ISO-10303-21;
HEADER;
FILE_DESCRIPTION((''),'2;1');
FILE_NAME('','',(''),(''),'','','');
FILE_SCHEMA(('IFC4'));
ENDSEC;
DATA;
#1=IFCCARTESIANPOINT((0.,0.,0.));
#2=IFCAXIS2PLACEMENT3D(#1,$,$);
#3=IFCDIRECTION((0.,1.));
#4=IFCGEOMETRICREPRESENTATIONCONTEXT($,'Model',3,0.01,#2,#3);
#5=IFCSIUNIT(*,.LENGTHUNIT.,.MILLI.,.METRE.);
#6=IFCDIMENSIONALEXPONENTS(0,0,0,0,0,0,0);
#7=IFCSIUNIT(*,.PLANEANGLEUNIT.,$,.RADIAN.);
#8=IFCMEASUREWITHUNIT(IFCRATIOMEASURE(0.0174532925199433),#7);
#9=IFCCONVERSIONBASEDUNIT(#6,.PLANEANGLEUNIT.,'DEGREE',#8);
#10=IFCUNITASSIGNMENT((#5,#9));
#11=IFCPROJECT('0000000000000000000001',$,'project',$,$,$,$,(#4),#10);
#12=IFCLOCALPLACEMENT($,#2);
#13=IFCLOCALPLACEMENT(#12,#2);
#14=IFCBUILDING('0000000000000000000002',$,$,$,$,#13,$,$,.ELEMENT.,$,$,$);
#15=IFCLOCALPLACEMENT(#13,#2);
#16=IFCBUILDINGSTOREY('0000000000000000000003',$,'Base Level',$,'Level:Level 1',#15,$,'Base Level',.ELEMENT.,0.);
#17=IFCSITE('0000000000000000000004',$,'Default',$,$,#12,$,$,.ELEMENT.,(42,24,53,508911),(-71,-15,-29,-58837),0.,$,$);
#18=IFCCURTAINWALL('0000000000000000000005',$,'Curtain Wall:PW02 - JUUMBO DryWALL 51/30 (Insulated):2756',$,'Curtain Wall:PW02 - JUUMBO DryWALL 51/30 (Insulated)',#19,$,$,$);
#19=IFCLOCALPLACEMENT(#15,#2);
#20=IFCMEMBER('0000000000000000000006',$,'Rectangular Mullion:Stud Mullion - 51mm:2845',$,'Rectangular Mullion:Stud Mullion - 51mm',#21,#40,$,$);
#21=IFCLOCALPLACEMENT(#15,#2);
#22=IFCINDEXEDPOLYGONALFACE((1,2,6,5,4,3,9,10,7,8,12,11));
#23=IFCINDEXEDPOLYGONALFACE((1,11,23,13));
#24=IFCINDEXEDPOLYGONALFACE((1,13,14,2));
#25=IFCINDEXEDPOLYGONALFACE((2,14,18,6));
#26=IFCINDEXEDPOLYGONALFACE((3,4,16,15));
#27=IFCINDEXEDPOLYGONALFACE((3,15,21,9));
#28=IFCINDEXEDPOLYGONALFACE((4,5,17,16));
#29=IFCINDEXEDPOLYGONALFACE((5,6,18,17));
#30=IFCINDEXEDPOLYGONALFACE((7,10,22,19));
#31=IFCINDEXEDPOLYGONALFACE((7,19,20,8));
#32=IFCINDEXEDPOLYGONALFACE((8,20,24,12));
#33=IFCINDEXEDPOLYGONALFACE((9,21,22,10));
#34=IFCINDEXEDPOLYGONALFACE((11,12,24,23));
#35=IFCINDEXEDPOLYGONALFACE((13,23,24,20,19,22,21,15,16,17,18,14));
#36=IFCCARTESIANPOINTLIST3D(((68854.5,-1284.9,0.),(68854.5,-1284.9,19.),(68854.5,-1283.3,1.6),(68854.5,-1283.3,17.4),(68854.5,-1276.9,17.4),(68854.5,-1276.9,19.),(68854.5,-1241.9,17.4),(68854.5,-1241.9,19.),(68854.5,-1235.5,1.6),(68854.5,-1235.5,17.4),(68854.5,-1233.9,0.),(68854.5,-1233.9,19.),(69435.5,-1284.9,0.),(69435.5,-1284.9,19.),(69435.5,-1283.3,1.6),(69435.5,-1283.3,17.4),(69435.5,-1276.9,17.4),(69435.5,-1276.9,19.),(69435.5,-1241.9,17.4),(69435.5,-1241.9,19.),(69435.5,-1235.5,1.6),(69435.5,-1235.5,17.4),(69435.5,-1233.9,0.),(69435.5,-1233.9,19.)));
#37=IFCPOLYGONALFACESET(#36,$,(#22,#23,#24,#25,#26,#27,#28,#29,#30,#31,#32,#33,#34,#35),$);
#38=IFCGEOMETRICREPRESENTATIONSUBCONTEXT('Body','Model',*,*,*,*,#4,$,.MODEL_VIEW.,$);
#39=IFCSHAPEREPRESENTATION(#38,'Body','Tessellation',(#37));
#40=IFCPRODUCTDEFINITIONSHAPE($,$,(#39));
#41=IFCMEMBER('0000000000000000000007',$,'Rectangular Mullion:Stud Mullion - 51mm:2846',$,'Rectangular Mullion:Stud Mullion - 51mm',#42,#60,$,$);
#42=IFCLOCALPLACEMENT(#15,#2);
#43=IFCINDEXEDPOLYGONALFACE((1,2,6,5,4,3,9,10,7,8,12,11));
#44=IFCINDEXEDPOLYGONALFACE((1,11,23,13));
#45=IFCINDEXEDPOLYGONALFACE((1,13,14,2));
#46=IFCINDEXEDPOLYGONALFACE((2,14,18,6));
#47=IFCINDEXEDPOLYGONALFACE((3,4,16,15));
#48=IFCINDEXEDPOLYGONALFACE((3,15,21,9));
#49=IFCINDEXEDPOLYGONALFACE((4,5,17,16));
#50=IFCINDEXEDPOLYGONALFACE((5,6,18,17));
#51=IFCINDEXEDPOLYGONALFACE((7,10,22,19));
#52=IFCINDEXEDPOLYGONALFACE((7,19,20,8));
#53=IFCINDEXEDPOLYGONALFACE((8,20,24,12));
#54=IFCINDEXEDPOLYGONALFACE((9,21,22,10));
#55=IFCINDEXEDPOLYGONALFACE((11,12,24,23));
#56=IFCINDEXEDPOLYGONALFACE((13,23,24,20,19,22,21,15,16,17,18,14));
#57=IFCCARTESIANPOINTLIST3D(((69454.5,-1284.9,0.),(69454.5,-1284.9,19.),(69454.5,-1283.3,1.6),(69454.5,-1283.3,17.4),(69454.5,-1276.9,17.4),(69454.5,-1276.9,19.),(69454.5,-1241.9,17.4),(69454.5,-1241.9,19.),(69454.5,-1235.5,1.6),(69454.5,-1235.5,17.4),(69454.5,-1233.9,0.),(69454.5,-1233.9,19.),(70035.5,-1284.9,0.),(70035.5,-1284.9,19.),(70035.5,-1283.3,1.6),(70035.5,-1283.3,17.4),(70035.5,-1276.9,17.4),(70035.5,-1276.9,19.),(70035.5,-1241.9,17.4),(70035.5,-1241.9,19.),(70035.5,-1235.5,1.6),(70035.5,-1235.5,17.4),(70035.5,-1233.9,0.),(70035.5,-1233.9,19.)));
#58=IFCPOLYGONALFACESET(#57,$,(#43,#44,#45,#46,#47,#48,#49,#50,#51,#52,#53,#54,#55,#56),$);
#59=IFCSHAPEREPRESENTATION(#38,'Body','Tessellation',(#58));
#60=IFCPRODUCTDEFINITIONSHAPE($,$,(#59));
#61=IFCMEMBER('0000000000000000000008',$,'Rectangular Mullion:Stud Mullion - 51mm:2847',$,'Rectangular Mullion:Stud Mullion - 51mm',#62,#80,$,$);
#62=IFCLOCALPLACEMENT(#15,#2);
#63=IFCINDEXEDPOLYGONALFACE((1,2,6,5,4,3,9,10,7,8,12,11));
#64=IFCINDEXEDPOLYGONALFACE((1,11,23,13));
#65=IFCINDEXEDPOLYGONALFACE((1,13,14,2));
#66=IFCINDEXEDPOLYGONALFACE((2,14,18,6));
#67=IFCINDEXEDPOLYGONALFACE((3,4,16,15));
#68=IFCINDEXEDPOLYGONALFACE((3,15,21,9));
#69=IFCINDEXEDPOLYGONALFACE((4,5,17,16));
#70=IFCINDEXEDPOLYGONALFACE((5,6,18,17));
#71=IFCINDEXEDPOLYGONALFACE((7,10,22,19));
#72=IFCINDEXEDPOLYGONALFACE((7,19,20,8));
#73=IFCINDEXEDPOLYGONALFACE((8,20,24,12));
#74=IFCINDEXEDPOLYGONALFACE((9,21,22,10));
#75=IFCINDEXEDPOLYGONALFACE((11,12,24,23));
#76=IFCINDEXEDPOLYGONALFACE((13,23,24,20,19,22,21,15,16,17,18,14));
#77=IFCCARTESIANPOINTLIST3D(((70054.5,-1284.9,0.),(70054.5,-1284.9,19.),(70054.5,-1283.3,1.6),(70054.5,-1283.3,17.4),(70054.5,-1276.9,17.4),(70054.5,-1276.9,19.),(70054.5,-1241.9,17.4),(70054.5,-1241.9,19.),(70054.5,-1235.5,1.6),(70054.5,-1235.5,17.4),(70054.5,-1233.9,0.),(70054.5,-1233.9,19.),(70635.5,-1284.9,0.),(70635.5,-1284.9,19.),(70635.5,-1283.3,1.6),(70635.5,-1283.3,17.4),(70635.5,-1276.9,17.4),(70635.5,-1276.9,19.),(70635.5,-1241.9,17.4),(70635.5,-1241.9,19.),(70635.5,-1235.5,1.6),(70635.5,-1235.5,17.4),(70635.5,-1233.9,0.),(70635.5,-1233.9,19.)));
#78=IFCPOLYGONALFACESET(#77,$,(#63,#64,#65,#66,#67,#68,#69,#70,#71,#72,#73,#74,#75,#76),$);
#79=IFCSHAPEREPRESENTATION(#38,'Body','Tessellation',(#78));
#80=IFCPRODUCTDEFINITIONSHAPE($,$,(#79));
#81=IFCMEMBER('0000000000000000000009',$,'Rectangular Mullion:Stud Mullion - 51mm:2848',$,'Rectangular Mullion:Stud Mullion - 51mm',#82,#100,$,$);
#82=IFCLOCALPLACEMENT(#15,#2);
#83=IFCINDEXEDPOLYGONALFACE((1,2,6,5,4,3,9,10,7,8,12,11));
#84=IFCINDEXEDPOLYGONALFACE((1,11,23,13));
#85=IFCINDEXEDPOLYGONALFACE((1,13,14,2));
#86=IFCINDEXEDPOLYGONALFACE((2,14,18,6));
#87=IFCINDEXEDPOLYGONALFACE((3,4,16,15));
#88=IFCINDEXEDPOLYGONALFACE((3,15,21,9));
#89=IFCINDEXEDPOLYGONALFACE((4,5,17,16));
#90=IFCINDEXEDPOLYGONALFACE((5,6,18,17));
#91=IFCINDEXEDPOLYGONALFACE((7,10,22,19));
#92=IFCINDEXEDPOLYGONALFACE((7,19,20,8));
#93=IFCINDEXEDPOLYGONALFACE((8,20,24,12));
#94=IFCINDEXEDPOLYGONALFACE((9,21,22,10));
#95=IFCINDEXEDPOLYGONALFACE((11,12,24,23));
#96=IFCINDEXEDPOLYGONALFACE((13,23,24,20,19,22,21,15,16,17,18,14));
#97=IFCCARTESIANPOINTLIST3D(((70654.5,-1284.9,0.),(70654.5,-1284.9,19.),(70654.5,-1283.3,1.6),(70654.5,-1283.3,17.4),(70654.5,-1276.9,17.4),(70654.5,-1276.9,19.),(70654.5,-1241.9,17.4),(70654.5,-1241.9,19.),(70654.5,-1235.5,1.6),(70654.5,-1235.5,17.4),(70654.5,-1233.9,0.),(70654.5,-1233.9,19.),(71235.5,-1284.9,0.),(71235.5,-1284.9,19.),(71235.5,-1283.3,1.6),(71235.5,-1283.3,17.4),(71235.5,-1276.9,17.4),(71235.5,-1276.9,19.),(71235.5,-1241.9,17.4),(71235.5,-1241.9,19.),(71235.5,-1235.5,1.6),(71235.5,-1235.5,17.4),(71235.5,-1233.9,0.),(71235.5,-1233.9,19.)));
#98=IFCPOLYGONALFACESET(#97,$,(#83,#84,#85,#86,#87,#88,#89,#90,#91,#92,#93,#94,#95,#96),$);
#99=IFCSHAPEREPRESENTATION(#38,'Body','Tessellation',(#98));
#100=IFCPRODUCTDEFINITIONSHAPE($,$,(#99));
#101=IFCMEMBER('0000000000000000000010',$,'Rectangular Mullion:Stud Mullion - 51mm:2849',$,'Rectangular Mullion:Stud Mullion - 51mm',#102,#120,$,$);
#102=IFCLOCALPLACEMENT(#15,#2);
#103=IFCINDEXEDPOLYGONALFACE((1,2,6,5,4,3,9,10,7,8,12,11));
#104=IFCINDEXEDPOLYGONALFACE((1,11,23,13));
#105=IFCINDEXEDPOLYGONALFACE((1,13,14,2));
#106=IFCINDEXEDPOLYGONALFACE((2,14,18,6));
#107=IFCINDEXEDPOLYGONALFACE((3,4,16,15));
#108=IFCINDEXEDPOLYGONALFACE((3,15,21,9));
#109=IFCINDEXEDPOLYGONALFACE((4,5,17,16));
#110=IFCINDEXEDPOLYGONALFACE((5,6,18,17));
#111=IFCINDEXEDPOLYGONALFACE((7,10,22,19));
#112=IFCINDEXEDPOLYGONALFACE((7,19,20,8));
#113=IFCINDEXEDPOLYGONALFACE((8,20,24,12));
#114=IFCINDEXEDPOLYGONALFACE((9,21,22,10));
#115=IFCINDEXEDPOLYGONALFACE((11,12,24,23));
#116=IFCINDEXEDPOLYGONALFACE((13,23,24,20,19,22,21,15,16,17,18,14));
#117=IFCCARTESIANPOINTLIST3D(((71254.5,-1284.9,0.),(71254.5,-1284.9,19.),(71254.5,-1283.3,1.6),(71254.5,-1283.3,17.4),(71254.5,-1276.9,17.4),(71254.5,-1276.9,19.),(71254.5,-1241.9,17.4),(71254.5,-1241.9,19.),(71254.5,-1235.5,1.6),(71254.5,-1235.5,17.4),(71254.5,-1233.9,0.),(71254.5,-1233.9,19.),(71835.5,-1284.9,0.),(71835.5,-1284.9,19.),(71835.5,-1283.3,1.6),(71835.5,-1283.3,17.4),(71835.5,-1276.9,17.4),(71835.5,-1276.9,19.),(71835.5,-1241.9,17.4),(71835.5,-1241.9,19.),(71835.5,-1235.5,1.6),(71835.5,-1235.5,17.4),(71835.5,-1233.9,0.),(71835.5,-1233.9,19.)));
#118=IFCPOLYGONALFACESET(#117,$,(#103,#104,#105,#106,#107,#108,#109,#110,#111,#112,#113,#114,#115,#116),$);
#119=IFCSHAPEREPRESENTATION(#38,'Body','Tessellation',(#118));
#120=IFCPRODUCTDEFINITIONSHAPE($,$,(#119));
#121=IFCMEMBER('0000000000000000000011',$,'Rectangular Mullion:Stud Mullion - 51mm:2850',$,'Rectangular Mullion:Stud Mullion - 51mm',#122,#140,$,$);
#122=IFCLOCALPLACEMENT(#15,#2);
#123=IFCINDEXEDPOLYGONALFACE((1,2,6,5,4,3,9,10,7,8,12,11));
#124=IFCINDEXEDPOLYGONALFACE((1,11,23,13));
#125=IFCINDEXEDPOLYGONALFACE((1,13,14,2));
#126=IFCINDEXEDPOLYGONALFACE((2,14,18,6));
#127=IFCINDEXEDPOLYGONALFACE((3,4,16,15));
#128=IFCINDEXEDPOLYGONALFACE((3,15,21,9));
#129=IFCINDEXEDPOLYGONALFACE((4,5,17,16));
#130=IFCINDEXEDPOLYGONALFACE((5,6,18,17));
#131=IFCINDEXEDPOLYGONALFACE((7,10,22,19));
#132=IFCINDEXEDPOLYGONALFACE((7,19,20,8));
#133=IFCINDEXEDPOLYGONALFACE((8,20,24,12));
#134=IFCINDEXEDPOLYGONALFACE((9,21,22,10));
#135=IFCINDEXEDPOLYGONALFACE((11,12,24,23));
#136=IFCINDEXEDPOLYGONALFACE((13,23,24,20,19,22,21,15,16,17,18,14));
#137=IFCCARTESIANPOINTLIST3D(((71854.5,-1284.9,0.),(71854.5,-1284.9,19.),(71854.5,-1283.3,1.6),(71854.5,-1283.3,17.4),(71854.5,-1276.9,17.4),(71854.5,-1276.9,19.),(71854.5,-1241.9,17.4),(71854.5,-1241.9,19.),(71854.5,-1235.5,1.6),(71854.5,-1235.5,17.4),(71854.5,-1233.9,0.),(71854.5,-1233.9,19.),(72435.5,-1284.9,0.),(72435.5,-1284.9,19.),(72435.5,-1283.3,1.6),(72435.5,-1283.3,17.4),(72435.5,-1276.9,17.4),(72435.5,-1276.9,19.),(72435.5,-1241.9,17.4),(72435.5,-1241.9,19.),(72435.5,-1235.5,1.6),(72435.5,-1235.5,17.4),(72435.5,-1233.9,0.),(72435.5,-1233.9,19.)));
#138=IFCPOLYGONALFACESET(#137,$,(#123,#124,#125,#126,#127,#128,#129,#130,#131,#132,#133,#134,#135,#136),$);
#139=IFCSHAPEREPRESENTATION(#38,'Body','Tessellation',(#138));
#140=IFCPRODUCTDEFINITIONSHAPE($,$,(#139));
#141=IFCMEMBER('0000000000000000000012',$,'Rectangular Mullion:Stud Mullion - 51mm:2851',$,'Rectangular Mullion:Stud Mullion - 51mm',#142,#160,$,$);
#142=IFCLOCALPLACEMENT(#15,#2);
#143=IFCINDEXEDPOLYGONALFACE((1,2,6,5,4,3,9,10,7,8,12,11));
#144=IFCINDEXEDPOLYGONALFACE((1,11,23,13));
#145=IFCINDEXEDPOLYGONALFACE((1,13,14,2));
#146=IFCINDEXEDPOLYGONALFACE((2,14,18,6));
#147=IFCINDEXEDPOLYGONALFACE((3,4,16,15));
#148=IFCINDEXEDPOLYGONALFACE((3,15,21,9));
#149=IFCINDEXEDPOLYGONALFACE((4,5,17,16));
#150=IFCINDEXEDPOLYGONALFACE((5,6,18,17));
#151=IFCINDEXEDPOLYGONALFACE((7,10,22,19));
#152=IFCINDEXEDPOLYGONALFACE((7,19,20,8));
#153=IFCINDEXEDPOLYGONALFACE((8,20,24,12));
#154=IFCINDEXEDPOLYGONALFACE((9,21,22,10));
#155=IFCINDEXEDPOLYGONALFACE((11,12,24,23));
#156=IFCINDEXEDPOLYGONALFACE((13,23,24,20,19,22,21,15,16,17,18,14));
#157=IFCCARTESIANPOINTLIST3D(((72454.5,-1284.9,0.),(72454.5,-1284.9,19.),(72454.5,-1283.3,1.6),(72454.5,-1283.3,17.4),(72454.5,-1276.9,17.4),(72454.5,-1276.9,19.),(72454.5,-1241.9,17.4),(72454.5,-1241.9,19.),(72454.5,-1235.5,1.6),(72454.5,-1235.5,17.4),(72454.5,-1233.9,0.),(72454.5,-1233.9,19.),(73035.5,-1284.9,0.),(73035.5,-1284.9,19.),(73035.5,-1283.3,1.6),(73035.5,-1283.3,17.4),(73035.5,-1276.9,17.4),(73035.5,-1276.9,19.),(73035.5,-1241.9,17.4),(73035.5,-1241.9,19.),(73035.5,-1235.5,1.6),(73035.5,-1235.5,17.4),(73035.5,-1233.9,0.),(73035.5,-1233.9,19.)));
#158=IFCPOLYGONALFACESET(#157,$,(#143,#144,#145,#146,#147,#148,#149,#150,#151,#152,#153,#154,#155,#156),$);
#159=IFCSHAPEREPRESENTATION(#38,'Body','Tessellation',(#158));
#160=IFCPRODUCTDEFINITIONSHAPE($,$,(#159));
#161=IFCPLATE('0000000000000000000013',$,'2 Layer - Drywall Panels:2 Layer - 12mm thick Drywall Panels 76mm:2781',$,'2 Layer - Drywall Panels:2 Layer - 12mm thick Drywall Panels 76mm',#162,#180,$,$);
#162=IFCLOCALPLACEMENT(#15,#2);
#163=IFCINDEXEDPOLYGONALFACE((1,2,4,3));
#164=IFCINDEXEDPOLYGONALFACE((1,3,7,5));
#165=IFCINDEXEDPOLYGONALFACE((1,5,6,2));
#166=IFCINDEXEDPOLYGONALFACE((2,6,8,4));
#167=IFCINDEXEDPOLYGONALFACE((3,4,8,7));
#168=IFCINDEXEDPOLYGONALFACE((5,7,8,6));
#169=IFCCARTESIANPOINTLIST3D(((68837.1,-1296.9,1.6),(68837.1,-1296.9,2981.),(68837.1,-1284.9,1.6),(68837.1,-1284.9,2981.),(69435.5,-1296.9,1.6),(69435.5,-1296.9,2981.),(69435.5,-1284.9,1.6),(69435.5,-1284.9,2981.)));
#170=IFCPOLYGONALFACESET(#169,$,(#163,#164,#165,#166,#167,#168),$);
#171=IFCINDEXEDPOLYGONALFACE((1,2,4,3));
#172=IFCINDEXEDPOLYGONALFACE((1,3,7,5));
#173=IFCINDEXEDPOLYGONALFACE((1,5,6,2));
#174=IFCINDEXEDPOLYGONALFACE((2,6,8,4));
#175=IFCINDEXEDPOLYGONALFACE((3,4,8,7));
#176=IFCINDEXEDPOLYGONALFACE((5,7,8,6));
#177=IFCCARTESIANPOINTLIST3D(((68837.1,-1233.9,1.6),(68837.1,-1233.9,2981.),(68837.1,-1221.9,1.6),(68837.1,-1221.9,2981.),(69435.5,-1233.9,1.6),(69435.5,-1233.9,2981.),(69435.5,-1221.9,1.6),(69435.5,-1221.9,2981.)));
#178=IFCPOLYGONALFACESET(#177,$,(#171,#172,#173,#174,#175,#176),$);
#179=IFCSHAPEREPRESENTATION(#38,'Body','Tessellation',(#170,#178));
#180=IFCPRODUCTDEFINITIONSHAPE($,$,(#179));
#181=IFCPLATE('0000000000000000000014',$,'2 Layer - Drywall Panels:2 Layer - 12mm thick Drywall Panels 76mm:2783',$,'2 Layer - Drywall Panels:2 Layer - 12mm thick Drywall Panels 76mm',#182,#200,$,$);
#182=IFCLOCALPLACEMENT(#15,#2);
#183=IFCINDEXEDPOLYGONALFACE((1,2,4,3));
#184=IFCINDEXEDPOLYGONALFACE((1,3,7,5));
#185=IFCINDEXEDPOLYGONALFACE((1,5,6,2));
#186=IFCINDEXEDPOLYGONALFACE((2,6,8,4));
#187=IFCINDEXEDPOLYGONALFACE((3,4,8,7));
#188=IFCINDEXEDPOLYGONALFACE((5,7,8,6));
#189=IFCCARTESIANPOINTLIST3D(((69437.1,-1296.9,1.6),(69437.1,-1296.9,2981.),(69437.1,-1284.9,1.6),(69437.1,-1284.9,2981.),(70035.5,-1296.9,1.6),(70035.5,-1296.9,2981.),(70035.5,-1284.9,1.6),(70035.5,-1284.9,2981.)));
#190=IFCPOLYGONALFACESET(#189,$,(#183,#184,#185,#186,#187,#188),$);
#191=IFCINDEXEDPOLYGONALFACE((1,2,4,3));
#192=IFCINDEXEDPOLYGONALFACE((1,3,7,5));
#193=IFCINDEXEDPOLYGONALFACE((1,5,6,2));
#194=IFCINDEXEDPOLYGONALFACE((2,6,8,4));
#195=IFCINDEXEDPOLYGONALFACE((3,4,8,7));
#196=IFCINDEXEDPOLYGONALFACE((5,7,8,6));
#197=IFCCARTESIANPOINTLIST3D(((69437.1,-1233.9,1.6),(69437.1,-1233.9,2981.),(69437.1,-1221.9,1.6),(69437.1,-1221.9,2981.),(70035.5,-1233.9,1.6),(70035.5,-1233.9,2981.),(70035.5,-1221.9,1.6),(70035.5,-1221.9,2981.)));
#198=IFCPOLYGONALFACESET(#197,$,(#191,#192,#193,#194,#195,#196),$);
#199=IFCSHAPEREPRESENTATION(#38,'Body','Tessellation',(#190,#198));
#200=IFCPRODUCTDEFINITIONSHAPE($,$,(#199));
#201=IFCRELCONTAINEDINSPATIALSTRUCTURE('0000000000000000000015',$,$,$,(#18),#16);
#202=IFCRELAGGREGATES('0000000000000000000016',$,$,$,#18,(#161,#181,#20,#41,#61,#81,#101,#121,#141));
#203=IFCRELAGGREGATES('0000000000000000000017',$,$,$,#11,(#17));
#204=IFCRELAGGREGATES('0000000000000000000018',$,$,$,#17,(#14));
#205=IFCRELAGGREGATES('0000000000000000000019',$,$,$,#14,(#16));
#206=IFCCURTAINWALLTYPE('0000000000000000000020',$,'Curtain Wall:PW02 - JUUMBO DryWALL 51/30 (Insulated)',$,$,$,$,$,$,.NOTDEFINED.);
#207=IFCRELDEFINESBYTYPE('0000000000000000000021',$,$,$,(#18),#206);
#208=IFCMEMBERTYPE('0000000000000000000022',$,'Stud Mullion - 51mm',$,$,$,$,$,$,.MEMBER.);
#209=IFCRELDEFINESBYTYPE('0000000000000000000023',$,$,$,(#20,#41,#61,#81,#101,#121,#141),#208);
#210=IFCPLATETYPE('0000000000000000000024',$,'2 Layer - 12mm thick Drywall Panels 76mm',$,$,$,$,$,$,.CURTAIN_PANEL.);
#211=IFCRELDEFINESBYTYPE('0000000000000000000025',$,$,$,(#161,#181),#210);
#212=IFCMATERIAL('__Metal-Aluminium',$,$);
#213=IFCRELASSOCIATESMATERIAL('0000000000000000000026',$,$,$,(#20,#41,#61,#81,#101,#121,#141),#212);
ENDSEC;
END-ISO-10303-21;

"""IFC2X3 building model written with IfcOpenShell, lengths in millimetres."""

from ifc_helpers import new_model, entity, si_unit, converted_unit, direction, frame, frame_2d, origin, origin_2d_with_axis, place, context, subcontext, project, spatial, polyline, rectangle, outline, extrude, source, transform, mapped, material, type_object, type_shapes, element, aggregate, save


model = new_model("IFC2X3")

# Units and contexts
model_context = context("Model", 3, precision=0.01, world=origin(), true_north=direction((0.0, 1.0)))
body_context = subcontext(model_context, "Body", "Model", "MODEL_VIEW")
ifc_project = project(units=[si_unit("LENGTHUNIT", "METRE", prefix="MILLI"), converted_unit("PLANEANGLEUNIT", "DEGREE", entity("IfcRatioMeasure", 0.0174532925199433), si_unit("PLANEANGLEUNIT", "RADIAN"), dimensions=[0, 0, 0, 0, 0, 0, 0])], contexts=[model_context])

# Site, building, storey
site_placement = place(None, origin())
site = spatial("IfcSite", under=ifc_project, at=site_placement, Name="Default", CompositionType="ELEMENT", RefLatitude=(42, 24, 53, 508911), RefLongitude=(-71, -15, -29, -58837), RefElevation=0.0)
building_placement = place(site_placement, origin())
building = spatial("IfcBuilding", under=site, at=building_placement, CompositionType="ELEMENT")
storey_placement = place(building_placement, origin())
storey = spatial("IfcBuildingStorey", under=building, at=storey_placement, Name="Base Level", ObjectType="Level:Level 1", LongName="Base Level", CompositionType="ELEMENT", Elevation=0.0)

# Curtain wall, members, plates
curtain_wall_type = type_object("IfcCurtainWallType", Name="Curtain Wall:PW02 - JUUMBO DryWALL 51/30 (Insulated)", PredefinedType="NOTDEFINED")
curtain_wall_placement = place(building_placement, origin())
curtain_wall = element("IfcCurtainWall", 1, at=curtain_wall_placement, inside=storey, type_object=curtain_wall_type, Name="Curtain Wall:PW02 - JUUMBO DryWALL 51/30 (Insulated):2756", ObjectType="Curtain Wall:PW02 - JUUMBO DryWALL 51/30 (Insulated)")
ifc_material = material(Name="__Metal-Aluminium")
member_type_1 = type_object("IfcMemberType", Name="Stud Mullion - 51mm", PredefinedType="MEMBER")
shared_shape_1 = source(origin(), body_context, "Body", "SweptSolid", [
    extrude(outline(polyline([(17.5, -6.6), (25.5, -6.6), (25.5, 12.4), (-25.5, 12.4), (-25.5, -6.6), (-17.5, -6.6), (-17.5, -5.0), (-23.9, -5.0), (-23.9, 10.8), (23.9, 10.8), (23.9, -5.0), (17.5, -5.0), (17.5, -6.6)])), frame((-12.4, 0.0, -581.0), z_axis=(0.0, 0.0, 1.0), x_axis=(0.0, -1.0, 0.0)), (0.0, 0.0, 1.0), 581.0),
])
type_shapes(member_type_1, [shared_shape_1])
member_1_placement = place(building_placement, frame((68854.5, -1259.4, 0.0), z_axis=(-1.0, 0.0, 0.0), x_axis=(0.0, 0.0, -1.0)))
member_1 = element("IfcMember", 2, at=member_1_placement, type_object=member_type_1, material=ifc_material, Name="Rectangular Mullion:Stud Mullion - 51mm:2845", ObjectType="Rectangular Mullion:Stud Mullion - 51mm", context=body_context, shape_type="MappedRepresentation", body=[
    mapped(shared_shape_1, transform((0.0, 0.0, 0.0), scale=1.0)),
])
member_2_placement = place(building_placement, frame((69454.5, -1259.4, 0.0), z_axis=(-1.0, 0.0, 0.0), x_axis=(0.0, 0.0, -1.0)))
member_2 = element("IfcMember", 3, at=member_2_placement, type_object=member_type_1, material=ifc_material, Name="Rectangular Mullion:Stud Mullion - 51mm:2846", ObjectType="Rectangular Mullion:Stud Mullion - 51mm", context=body_context, shape_type="MappedRepresentation", body=[
    mapped(shared_shape_1, transform((0.0, 0.0, 0.0), scale=1.0)),
])
member_3_placement = place(building_placement, frame((70054.5, -1259.4, 0.0), z_axis=(-1.0, 0.0, 0.0), x_axis=(0.0, 0.0, -1.0)))
member_3 = element("IfcMember", 4, at=member_3_placement, type_object=member_type_1, material=ifc_material, Name="Rectangular Mullion:Stud Mullion - 51mm:2847", ObjectType="Rectangular Mullion:Stud Mullion - 51mm", context=body_context, shape_type="MappedRepresentation", body=[
    mapped(shared_shape_1, transform((0.0, 0.0, 0.0), scale=1.0)),
])
member_4_placement = place(building_placement, frame((70654.5, -1259.4, 0.0), z_axis=(-1.0, 0.0, 0.0), x_axis=(0.0, 0.0, -1.0)))
member_4 = element("IfcMember", 5, at=member_4_placement, type_object=member_type_1, material=ifc_material, Name="Rectangular Mullion:Stud Mullion - 51mm:2848", ObjectType="Rectangular Mullion:Stud Mullion - 51mm", context=body_context, shape_type="MappedRepresentation", body=[
    mapped(shared_shape_1, transform((0.0, 0.0, 0.0), scale=1.0)),
])
member_5_placement = place(building_placement, frame((71254.5, -1259.4, 0.0), z_axis=(-1.0, 0.0, 0.0), x_axis=(0.0, 0.0, -1.0)))
member_5 = element("IfcMember", 6, at=member_5_placement, type_object=member_type_1, material=ifc_material, Name="Rectangular Mullion:Stud Mullion - 51mm:2849", ObjectType="Rectangular Mullion:Stud Mullion - 51mm", context=body_context, shape_type="MappedRepresentation", body=[
    mapped(shared_shape_1, transform((0.0, 0.0, 0.0), scale=1.0)),
])
member_6_placement = place(building_placement, frame((71854.5, -1259.4, 0.0), z_axis=(-1.0, 0.0, 0.0), x_axis=(0.0, 0.0, -1.0)))
member_6 = element("IfcMember", 7, at=member_6_placement, type_object=member_type_1, material=ifc_material, Name="Rectangular Mullion:Stud Mullion - 51mm:2850", ObjectType="Rectangular Mullion:Stud Mullion - 51mm", context=body_context, shape_type="MappedRepresentation", body=[
    mapped(shared_shape_1, transform((0.0, 0.0, 0.0), scale=1.0)),
])
member_7_placement = place(building_placement, frame((72454.5, -1259.4, 0.0), z_axis=(-1.0, 0.0, 0.0), x_axis=(0.0, 0.0, -1.0)))
member_7 = element("IfcMember", 8, at=member_7_placement, type_object=member_type_1, material=ifc_material, Name="Rectangular Mullion:Stud Mullion - 51mm:2851", ObjectType="Rectangular Mullion:Stud Mullion - 51mm", context=body_context, shape_type="MappedRepresentation", body=[
    mapped(shared_shape_1, transform((0.0, 0.0, 0.0), scale=1.0)),
])
plate_type = type_object("IfcPlateType", Name="2 Layer - 12mm thick Drywall Panels 76mm", PredefinedType="CURTAIN_PANEL")
shared_shape_2 = source(origin(), body_context, "Body", "SweptSolid", [
    extrude(rectangle(XDim=598.4, YDim=12.0, at=origin_2d_with_axis()), frame((0.0, -31.5, 0.0), z_axis=(0.0, 0.0, 1.0), x_axis=(-1.0, 0.0, 0.0)), (0.0, 0.0, 1.0), 2979.4),
    extrude(rectangle(XDim=12.0, YDim=598.4, at=frame_2d((0.0, 0.0), x_axis=(1.0, 0.0))), frame((0.0, 31.5, 0.0), z_axis=(0.0, 0.0, 1.0), x_axis=(0.0, 1.0, 0.0)), (0.0, 0.0, 1.0), 2979.4),
])
type_shapes(plate_type, [shared_shape_2])
plate_1_placement = place(curtain_wall_placement, frame((69136.3, -1259.4, 1.6)))
plate_1 = element("IfcPlate", 9, at=plate_1_placement, type_object=plate_type, Name="2 Layer - Drywall Panels:2 Layer - 12mm thick Drywall Panels 76mm:2781", ObjectType="2 Layer - Drywall Panels:2 Layer - 12mm thick Drywall Panels 76mm", context=body_context, shape_type="MappedRepresentation", body=[
    mapped(shared_shape_2, transform((0.0, 0.0, 0.0), scale=1.0)),
])
plate_2_placement = place(curtain_wall_placement, frame((69736.3, -1259.4, 1.6)))
plate_2 = element("IfcPlate", 10, at=plate_2_placement, type_object=plate_type, Name="2 Layer - Drywall Panels:2 Layer - 12mm thick Drywall Panels 76mm:2783", ObjectType="2 Layer - Drywall Panels:2 Layer - 12mm thick Drywall Panels 76mm", context=body_context, shape_type="MappedRepresentation", body=[
    mapped(shared_shape_2, transform((0.0, 0.0, 0.0), scale=1.0)),
])
aggregate(curtain_wall, [plate_1, plate_2, member_1, member_2, member_3, member_4, member_5, member_6, member_7])

save(model, "model.ifc")
